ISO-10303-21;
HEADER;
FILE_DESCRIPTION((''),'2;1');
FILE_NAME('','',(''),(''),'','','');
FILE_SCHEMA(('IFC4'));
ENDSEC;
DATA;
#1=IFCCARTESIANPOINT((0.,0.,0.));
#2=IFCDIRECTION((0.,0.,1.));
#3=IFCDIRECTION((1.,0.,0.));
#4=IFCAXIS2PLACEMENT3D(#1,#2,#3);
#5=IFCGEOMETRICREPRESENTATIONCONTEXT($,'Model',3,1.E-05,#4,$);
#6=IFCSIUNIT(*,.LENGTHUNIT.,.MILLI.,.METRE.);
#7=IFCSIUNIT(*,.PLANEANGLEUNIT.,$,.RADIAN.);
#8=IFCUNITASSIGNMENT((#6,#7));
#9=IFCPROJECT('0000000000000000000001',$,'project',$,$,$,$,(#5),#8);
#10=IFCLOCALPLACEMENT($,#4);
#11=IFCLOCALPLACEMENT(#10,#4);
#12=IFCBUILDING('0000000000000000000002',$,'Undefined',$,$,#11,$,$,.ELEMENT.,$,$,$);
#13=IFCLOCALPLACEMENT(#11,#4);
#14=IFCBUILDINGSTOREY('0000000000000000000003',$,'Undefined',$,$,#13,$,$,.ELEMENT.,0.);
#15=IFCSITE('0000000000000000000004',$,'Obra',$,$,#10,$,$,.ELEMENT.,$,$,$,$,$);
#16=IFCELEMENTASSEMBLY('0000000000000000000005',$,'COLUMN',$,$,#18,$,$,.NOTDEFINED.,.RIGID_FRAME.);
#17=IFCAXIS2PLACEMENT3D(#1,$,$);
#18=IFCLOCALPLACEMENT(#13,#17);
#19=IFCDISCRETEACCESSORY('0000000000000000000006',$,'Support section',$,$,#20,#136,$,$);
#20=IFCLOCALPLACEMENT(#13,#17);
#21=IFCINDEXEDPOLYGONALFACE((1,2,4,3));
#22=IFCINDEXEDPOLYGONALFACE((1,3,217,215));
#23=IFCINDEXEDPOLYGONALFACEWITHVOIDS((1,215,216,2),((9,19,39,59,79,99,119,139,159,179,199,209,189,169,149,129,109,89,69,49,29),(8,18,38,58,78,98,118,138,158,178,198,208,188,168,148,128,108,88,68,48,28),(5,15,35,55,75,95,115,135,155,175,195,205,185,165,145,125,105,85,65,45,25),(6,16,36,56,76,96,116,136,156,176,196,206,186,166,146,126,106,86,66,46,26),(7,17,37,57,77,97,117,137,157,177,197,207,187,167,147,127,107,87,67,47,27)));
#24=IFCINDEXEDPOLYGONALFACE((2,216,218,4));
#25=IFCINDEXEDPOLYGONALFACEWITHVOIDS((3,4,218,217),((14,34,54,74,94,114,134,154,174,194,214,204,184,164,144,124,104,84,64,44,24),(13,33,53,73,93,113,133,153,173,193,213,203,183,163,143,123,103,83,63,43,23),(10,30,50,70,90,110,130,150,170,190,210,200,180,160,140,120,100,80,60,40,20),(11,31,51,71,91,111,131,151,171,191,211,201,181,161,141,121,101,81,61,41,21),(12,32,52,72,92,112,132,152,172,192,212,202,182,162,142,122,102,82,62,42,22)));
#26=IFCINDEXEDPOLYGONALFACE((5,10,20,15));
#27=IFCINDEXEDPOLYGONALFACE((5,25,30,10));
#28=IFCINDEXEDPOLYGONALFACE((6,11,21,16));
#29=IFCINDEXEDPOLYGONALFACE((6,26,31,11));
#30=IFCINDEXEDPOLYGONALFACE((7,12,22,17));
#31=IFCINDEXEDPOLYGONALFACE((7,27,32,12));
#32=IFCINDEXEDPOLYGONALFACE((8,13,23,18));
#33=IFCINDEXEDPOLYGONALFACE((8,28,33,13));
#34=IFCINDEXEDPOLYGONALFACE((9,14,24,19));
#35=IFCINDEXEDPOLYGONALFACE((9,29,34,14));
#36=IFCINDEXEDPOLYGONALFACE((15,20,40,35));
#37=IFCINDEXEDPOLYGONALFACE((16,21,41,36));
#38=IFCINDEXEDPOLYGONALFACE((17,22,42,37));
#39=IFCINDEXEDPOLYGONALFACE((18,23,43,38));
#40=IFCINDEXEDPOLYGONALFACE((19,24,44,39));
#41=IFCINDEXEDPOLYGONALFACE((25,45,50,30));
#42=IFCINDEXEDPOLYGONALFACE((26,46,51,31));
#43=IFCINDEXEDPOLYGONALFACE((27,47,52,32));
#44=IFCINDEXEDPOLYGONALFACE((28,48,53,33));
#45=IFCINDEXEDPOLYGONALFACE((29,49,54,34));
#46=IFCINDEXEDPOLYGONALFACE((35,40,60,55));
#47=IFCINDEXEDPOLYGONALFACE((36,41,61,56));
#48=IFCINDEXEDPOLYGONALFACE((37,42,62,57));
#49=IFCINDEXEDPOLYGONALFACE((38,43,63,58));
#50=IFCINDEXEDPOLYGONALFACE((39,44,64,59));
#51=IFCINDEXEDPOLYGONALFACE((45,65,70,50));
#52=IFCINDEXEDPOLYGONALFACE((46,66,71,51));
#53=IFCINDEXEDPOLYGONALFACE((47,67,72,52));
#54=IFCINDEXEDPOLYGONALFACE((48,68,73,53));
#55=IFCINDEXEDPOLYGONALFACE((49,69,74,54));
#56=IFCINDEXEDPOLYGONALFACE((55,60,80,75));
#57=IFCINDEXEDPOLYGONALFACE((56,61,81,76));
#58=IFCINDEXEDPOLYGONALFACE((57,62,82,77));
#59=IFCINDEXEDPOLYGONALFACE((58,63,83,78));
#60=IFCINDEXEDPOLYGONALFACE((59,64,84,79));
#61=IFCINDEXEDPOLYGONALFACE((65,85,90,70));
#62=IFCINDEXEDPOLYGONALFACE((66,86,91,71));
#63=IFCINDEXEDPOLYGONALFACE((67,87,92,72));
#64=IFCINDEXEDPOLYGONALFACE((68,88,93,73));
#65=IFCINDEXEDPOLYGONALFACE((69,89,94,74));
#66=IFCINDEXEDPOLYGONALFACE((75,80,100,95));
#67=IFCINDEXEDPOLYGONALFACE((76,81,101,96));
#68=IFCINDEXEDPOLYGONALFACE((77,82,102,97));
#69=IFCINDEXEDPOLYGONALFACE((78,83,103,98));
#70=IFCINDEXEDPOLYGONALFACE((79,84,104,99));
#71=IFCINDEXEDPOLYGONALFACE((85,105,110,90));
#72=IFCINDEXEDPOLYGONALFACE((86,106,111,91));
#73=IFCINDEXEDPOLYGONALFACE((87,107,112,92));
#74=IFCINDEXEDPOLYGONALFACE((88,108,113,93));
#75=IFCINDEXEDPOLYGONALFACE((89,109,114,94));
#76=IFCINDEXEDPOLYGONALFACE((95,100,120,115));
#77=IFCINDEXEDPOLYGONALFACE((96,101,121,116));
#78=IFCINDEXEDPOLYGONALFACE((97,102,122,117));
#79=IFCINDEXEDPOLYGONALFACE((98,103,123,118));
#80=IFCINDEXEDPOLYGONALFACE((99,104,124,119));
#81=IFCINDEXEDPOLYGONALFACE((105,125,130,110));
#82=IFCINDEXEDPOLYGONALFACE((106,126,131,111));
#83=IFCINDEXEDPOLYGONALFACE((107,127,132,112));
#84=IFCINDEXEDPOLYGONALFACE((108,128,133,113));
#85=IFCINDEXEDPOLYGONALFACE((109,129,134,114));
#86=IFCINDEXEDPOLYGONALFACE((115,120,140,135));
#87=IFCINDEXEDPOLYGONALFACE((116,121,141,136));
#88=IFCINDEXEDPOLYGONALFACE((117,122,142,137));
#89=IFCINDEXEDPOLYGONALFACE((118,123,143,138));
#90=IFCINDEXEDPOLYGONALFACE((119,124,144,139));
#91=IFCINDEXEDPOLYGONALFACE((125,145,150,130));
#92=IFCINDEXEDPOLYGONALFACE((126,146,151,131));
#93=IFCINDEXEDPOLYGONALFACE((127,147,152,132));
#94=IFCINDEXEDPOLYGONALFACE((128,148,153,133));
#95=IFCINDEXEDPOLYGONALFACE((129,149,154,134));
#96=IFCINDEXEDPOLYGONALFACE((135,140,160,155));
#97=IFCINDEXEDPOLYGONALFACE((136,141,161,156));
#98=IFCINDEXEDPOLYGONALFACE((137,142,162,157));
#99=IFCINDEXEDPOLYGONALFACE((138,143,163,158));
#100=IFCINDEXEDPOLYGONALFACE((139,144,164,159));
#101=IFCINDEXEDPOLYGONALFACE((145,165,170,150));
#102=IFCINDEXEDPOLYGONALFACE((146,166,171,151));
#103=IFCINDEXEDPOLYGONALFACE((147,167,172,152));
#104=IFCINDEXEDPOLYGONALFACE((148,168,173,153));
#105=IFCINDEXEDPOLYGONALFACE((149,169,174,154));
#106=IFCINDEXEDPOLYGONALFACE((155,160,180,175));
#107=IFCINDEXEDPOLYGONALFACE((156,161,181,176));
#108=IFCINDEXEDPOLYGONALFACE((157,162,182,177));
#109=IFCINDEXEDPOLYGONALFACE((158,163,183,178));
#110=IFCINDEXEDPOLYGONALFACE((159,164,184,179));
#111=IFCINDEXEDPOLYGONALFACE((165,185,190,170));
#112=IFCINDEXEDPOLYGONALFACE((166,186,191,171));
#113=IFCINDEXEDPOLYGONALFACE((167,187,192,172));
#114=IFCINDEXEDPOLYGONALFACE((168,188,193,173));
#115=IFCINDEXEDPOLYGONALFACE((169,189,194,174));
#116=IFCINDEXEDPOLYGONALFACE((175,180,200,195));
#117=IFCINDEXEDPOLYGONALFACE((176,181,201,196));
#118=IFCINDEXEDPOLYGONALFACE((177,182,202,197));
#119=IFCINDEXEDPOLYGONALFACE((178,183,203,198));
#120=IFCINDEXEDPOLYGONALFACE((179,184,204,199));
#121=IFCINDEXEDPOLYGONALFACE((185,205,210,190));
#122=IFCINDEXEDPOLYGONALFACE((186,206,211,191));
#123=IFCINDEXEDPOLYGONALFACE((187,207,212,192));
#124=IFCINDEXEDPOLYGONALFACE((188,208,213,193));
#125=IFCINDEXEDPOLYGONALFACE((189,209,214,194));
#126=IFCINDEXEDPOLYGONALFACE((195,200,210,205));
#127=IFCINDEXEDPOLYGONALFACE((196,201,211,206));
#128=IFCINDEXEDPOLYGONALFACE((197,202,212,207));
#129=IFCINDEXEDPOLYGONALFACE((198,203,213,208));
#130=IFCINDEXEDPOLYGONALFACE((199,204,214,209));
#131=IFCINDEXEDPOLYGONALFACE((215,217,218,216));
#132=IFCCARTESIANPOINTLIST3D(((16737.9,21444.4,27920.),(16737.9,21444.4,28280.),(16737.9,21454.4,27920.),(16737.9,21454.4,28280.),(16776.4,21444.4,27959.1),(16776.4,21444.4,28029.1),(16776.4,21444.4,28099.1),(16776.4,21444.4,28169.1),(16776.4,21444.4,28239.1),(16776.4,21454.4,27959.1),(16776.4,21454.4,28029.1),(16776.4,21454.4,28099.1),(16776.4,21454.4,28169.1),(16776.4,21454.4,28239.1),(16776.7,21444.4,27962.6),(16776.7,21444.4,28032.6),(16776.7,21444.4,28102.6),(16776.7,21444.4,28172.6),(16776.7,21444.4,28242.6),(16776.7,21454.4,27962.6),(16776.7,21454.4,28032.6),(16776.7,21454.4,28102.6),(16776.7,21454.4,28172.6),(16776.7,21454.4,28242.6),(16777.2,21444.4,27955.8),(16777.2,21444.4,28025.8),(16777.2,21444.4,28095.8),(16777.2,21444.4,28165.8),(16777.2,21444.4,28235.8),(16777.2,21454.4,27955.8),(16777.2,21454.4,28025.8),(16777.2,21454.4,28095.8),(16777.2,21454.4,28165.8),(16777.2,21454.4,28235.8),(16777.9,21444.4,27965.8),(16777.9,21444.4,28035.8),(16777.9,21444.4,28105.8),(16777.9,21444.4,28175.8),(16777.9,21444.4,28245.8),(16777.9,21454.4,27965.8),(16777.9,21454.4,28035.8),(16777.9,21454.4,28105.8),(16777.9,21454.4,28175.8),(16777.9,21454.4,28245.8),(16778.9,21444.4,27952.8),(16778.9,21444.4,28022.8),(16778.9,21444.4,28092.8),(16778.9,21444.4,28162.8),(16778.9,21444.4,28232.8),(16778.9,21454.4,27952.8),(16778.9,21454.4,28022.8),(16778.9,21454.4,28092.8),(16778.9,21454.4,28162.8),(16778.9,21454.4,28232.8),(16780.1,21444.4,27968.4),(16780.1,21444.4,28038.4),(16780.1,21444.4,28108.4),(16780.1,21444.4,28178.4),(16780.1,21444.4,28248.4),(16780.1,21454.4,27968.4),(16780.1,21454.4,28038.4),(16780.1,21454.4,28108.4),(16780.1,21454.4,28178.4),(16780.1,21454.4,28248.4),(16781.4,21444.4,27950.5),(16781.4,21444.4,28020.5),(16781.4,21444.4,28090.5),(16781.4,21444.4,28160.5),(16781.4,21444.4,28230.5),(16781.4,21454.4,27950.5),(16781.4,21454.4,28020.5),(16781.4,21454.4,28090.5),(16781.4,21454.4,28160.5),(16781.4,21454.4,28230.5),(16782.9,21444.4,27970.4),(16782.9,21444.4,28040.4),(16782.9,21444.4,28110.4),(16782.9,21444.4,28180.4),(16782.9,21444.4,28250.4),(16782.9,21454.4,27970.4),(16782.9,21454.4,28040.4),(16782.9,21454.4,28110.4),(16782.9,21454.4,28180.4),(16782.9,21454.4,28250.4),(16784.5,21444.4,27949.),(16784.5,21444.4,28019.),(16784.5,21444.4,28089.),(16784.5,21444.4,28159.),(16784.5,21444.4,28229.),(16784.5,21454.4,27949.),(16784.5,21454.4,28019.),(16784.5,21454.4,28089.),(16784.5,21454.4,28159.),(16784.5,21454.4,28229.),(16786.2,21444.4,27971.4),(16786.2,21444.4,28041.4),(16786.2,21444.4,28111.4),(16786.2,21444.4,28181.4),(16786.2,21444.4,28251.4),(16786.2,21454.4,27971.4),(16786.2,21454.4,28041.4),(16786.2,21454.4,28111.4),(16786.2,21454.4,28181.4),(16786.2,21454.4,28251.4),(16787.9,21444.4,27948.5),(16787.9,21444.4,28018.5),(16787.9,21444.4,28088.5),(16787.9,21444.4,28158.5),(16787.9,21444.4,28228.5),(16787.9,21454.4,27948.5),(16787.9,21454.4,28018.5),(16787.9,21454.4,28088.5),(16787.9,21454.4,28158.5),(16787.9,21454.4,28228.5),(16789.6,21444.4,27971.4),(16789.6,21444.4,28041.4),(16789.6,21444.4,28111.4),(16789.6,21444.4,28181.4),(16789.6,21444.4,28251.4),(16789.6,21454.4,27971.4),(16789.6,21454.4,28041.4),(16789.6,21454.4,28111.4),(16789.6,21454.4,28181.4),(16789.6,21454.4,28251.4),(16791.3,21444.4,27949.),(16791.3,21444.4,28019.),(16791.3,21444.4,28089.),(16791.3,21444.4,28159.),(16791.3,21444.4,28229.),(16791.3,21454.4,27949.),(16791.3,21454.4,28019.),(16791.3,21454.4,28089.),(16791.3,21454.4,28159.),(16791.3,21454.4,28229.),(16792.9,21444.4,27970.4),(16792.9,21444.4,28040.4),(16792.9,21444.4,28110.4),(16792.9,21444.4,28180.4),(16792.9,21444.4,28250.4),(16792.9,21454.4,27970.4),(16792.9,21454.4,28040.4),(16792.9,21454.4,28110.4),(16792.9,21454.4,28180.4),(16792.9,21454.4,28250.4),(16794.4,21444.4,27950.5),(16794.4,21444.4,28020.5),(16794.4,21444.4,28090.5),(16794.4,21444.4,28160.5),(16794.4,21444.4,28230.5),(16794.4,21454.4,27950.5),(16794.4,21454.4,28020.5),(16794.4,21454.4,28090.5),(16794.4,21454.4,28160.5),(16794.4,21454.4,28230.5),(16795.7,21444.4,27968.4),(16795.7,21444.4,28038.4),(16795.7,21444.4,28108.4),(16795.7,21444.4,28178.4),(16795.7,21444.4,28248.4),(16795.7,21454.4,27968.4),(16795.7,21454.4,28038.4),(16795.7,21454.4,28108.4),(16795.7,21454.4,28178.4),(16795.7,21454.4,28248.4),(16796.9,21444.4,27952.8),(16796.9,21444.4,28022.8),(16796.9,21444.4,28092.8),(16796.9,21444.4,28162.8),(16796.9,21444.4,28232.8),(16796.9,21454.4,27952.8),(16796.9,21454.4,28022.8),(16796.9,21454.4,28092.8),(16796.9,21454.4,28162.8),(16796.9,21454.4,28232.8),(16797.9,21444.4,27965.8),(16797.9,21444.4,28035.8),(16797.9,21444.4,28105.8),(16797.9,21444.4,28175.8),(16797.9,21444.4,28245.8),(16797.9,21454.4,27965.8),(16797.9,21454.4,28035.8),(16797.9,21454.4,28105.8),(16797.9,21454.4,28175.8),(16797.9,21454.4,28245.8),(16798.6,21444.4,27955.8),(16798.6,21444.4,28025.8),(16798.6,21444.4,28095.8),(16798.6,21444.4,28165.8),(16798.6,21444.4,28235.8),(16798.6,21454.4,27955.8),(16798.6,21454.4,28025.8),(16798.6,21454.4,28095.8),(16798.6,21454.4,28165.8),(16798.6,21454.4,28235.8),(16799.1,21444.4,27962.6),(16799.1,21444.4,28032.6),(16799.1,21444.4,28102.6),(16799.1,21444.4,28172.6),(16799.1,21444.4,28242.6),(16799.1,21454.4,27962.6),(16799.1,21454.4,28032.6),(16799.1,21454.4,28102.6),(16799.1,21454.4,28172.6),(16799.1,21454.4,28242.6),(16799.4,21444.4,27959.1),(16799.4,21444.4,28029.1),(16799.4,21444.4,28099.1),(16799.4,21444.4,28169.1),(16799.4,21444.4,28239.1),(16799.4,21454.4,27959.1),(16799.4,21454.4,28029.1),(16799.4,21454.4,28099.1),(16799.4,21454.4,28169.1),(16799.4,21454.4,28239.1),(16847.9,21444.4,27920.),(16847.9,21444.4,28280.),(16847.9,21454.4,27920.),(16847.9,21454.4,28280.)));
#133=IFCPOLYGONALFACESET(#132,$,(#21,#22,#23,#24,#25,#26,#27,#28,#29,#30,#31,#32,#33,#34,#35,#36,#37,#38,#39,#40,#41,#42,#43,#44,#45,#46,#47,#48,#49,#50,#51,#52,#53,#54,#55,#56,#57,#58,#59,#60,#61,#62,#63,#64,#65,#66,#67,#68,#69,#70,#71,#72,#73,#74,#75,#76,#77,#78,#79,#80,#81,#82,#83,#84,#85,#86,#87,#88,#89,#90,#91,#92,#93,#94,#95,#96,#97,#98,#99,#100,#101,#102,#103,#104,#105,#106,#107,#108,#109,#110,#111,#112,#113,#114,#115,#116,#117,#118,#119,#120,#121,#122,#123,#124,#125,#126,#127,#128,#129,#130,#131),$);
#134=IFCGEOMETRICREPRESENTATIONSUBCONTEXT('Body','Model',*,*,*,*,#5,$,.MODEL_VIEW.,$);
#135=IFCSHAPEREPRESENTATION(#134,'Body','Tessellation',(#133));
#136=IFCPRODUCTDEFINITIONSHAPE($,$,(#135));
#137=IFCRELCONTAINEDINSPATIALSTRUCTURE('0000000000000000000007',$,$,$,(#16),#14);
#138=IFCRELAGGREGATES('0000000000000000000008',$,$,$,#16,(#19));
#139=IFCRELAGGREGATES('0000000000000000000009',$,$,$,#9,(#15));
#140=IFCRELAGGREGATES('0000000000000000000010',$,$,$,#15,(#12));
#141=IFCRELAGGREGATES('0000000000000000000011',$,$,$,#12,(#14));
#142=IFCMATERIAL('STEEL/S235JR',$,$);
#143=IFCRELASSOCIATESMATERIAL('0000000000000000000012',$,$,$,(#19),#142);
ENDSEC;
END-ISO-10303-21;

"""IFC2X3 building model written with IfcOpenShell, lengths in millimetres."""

from ifc_helpers import new_model, si_unit, frame, origin_with_axes, origin_2d_with_axis, place, context, subcontext, project, spatial, rectangle, circle, extrude, source, transform, mapped, material, element, aggregate, save


model = new_model("IFC2X3")

# Units and contexts
model_context = context("Model", 3, precision=1e-05, world=origin_with_axes())
body_context = subcontext(model_context, "Body", "Model", "MODEL_VIEW")
ifc_project = project(units=[si_unit("LENGTHUNIT", "METRE", prefix="MILLI"), si_unit("PLANEANGLEUNIT", "RADIAN")], contexts=[model_context])

# Site, building, storey
site_placement = place(None, origin_with_axes())
site = spatial("IfcSite", under=ifc_project, at=site_placement, Name="Obra", CompositionType="ELEMENT")
building_placement = place(site_placement, origin_with_axes())
building = spatial("IfcBuilding", under=site, at=building_placement, Name="Undefined", CompositionType="ELEMENT")
storey_placement = place(building_placement, origin_with_axes())
storey = spatial("IfcBuildingStorey", under=building, at=storey_placement, Name="Undefined", CompositionType="ELEMENT", Elevation=0.0)

# Shared definitions
ifc_material_1 = material(Name="STEEL/S235JR")

# Shared definitions
shared_shape_1 = source(origin_with_axes(), body_context, "Body", "SweptSolid", [
    extrude(circle(Radius=11.5, at=origin_2d_with_axis()), frame((0.0, -14.4, 0.0), z_axis=(0.0, 1.0, 0.0), x_axis=(1.0, 0.0, 0.0)), (0.0, 0.0, 1.0), 10.2),
])

# Element assembly
assembly_1_placement = place(storey_placement, origin_with_axes())
assembly_1 = element("IfcElementAssembly", 1, at=assembly_1_placement, inside=storey, Name="COLUMN", AssemblyPlace="NOTDEFINED", PredefinedType="RIGID_FRAME")

# Discrete accessory, opening
discrete_accessory_1_placement = place(assembly_1_placement, frame((16792.9, 21449.4, 27920.0), z_axis=(0.0, 0.0, 1.0), x_axis=(1.0, 0.0, 0.0)))
discrete_accessory_1 = element("IfcDiscreteAccessory", 2, at=discrete_accessory_1_placement, material=ifc_material_1, Name="Support section", context=body_context, shape_type="SweptSolid", body=[
    extrude(rectangle(XDim=10.0, YDim=110.0, at=origin_2d_with_axis()), frame((0.0, 0.0, 360.0), z_axis=(0.0, 0.0, -1.0), x_axis=(0.0, 1.0, 0.0)), (0.0, 0.0, 1.0), 360.0),
])
opening_1_placement = place(assembly_1_placement, frame((16837.9, 21440.1, 28300.0), z_axis=(-1.0, 0.0, 0.0), x_axis=(0.0, 0.0, -1.0)))
element("IfcOpeningElement", 3, at=opening_1_placement, cuts=discrete_accessory_1, ObjectType="Opening", context=body_context, shape_type="MappedRepresentation", body=[
    mapped(shared_shape_1, transform((60.0, 0.0, 50.0))),
    mapped(shared_shape_1, transform((130.0, 0.0, 50.0))),
    mapped(shared_shape_1, transform((200.0, 0.0, 50.0))),
    mapped(shared_shape_1, transform((270.0, 0.0, 50.0))),
    mapped(shared_shape_1, transform((340.0, 0.0, 50.0))),
])
aggregate(assembly_1, [discrete_accessory_1])

save(model, "model.ifc")
